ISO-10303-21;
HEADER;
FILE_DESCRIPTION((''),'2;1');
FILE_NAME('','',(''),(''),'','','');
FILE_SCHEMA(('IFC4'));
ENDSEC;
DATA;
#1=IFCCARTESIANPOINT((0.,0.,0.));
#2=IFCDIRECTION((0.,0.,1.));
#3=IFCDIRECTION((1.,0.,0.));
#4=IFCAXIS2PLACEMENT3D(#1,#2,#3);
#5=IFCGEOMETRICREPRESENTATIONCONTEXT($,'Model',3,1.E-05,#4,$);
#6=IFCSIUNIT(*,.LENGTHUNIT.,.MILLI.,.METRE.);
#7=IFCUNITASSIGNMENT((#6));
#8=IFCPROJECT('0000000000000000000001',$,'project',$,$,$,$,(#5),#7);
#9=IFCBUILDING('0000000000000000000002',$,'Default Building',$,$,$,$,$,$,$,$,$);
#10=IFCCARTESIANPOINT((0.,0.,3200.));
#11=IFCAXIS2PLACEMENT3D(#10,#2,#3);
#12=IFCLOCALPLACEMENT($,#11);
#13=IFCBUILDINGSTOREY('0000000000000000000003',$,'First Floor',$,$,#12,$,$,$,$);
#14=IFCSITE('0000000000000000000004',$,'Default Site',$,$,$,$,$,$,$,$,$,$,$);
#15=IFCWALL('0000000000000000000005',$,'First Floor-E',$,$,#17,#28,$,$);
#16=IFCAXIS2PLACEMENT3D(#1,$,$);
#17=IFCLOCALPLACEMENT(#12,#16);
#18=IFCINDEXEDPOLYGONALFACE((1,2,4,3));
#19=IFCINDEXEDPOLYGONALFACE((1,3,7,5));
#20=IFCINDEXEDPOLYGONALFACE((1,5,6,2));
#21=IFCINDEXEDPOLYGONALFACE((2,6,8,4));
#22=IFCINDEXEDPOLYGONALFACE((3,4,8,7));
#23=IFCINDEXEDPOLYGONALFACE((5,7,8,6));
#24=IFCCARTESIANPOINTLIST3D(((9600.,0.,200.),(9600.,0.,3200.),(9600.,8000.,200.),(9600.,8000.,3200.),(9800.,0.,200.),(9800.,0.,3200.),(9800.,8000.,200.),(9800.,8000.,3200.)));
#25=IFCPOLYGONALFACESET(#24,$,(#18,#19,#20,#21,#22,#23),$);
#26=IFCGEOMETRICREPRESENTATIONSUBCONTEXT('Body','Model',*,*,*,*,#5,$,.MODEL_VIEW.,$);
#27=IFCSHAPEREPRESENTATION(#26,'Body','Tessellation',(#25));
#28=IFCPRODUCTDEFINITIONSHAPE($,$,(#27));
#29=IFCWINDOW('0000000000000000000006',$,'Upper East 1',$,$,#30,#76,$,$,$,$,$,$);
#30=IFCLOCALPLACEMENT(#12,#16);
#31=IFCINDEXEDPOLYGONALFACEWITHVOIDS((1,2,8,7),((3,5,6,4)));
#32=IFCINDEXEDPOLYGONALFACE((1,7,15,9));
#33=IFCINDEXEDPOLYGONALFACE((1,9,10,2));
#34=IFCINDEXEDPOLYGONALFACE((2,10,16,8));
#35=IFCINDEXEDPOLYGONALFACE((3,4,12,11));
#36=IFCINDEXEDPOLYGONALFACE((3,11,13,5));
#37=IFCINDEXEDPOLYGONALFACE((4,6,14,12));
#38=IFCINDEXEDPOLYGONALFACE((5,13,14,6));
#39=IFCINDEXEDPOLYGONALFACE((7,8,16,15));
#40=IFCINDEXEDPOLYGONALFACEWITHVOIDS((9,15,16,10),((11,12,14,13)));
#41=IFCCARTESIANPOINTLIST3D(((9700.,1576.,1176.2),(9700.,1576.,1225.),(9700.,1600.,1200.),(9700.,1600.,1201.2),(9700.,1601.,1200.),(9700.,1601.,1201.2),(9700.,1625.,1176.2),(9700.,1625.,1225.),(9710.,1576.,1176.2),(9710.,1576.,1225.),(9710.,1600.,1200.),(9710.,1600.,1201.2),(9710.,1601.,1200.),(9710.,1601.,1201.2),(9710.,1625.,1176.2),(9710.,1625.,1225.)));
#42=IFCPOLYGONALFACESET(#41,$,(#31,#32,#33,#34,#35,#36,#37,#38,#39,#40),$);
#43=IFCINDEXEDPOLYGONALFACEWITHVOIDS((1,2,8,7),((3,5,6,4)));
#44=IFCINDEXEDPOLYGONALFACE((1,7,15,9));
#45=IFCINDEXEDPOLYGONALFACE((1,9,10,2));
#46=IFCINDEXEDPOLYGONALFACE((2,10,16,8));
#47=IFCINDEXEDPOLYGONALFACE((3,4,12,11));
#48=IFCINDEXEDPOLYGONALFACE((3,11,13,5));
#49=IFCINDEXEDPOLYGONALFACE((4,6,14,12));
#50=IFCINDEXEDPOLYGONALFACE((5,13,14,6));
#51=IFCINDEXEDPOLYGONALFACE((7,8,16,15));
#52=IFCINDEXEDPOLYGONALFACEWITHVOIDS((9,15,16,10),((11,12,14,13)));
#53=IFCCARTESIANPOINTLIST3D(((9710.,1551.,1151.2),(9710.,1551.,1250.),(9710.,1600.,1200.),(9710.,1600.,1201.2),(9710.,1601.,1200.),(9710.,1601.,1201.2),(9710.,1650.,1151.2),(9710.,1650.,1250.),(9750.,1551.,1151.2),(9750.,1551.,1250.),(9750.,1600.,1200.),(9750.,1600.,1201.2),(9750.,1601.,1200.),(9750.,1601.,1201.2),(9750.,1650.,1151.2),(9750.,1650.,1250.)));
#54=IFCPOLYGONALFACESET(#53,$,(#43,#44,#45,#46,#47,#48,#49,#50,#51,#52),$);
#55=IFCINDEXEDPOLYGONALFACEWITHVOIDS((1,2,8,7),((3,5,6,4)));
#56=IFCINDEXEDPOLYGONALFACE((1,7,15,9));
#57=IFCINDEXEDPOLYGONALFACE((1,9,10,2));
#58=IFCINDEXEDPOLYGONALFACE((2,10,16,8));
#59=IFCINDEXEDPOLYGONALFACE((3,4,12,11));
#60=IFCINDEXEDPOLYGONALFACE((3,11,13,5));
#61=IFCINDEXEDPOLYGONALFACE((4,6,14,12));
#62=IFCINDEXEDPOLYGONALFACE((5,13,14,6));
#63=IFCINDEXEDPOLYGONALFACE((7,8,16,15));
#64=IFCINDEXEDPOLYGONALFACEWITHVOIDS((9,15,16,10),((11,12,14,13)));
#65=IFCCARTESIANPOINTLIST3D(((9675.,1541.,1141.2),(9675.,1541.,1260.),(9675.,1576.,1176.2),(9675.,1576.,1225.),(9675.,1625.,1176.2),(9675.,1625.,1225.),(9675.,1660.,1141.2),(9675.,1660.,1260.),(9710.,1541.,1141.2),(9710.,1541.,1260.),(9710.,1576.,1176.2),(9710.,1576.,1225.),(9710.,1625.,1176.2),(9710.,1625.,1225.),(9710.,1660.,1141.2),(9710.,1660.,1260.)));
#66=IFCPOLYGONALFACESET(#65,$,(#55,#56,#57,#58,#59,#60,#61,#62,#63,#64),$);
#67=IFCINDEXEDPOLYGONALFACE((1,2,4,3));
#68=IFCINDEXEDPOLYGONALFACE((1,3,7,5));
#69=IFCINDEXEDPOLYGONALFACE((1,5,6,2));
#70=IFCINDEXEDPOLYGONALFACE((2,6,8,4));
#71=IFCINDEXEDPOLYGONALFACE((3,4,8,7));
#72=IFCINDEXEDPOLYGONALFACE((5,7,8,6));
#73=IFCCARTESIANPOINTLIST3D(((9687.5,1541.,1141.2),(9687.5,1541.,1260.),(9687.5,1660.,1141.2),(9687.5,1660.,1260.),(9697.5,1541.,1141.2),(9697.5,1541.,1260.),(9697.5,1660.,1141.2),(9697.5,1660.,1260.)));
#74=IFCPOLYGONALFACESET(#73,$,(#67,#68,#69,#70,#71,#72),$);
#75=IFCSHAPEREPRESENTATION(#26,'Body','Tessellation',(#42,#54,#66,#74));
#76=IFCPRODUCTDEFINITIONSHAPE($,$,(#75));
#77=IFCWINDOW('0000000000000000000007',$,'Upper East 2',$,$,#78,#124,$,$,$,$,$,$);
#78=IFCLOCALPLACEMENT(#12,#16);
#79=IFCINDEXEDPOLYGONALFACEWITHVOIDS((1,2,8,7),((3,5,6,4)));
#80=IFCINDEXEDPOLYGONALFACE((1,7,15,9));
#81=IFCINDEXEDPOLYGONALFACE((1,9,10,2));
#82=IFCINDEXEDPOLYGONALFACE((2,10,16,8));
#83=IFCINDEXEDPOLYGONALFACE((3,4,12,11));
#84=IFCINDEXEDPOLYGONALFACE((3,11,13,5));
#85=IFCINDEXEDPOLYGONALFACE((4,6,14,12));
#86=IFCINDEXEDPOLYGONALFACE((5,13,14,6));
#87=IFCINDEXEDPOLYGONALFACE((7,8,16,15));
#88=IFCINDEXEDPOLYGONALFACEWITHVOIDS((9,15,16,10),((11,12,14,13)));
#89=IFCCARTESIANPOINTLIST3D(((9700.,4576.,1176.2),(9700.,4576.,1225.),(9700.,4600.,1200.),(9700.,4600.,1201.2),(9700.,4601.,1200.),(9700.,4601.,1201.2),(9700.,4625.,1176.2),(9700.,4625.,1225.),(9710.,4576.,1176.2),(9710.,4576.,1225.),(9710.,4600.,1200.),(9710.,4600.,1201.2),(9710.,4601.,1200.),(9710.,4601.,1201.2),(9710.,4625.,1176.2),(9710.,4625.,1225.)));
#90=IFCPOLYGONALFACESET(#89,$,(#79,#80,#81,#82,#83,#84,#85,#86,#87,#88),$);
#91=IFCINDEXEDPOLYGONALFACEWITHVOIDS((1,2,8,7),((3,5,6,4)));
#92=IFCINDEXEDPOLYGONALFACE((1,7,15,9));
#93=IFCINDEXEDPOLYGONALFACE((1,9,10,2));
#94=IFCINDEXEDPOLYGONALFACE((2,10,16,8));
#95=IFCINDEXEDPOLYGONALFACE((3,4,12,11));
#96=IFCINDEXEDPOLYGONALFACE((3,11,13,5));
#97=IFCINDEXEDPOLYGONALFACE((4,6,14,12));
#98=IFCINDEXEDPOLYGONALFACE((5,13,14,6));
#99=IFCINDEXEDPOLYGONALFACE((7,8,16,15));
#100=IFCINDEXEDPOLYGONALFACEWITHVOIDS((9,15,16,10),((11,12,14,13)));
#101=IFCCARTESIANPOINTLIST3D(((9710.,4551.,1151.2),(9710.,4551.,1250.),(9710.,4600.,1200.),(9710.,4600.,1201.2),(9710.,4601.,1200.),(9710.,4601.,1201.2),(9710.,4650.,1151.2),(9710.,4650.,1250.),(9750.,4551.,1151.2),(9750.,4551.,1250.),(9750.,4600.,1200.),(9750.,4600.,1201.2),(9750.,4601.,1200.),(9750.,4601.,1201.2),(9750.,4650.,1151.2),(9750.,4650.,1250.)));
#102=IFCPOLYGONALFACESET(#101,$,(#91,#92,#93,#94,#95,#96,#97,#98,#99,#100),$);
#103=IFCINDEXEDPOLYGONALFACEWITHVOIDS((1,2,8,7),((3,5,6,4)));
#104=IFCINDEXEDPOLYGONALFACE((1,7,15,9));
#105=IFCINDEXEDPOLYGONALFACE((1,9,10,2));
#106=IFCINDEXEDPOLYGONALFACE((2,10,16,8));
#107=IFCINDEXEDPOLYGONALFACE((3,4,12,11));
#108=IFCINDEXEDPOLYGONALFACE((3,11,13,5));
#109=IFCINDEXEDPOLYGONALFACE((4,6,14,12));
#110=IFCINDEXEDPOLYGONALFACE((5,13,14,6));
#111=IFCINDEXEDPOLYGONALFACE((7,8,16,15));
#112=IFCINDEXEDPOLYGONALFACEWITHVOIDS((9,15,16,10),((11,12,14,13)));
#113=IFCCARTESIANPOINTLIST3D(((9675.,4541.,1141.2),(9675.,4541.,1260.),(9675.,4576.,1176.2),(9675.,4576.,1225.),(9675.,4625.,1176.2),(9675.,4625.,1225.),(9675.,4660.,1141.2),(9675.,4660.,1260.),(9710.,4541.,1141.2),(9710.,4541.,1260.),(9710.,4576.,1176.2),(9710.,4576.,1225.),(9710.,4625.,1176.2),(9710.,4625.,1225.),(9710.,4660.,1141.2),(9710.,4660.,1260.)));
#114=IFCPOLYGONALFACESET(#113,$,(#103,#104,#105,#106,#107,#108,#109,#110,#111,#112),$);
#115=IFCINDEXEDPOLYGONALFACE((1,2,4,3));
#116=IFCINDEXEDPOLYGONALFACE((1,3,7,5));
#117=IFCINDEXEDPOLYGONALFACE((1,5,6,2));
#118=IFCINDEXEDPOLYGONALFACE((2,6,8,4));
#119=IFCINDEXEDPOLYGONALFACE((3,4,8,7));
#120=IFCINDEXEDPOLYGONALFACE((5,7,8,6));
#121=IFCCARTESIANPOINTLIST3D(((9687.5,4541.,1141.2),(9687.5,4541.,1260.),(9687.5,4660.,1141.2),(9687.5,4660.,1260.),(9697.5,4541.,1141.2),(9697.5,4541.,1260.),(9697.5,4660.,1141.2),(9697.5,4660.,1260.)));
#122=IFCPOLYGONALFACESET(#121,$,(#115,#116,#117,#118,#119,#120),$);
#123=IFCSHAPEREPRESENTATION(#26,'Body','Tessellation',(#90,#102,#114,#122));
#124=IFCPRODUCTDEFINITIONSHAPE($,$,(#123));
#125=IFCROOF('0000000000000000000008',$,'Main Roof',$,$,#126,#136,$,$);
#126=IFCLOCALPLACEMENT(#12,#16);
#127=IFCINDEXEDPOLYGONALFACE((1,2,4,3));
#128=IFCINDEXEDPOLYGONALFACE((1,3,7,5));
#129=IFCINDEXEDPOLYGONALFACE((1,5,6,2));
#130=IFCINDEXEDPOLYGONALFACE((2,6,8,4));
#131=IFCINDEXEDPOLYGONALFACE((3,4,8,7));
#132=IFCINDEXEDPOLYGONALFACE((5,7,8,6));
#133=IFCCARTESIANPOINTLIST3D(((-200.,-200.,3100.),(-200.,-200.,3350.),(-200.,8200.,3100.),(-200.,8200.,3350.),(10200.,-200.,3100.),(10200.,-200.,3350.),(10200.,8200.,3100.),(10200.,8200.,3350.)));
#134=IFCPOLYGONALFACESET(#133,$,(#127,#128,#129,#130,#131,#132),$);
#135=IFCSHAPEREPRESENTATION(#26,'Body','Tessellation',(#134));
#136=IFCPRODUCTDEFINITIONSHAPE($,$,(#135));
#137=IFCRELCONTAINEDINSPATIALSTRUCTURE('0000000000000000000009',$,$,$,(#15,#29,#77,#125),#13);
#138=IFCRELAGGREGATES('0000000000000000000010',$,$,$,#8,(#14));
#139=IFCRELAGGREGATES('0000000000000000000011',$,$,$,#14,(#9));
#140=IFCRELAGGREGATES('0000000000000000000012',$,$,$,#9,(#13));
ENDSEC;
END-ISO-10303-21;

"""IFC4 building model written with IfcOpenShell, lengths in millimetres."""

from ifc_helpers import new_model, si_unit, frame, origin_with_axes, place, context, subcontext, project, spatial, line, indexed_curve, outline, extrude, element, fill, save


model = new_model("IFC4")

# Units and contexts
model_context = context("Model", 3, precision=1e-05, world=origin_with_axes())
body_context = subcontext(model_context, "Body", "Model", "MODEL_VIEW")
ifc_project = project(units=[si_unit("LENGTHUNIT", "METRE", prefix="MILLI")], contexts=[model_context])

# Site, building, storey
site = spatial("IfcSite", under=ifc_project, Name="Default Site")
building = spatial("IfcBuilding", under=site, Name="Default Building")
storey_placement = place(None, frame((0.0, 0.0, 3200.0), z_axis=(0.0, 0.0, 1.0), x_axis=(1.0, 0.0, 0.0)))
storey = spatial("IfcBuildingStorey", under=building, at=storey_placement, Name="First Floor")

# Wall, openings, windows
wall_1_placement = place(storey_placement, frame((0.0, 0.0, 200.0), z_axis=(0.0, 0.0, 1.0), x_axis=(1.0, 0.0, 0.0)))
wall_1 = element("IfcWall", 1, at=wall_1_placement, inside=storey, Name="First Floor-E", context=body_context, shape_type="SweptSolid", body=[
    extrude(outline(indexed_curve([(9800.0, 0.0), (9800.0, 8000.0), (9600.0, 8000.0), (9600.0, 0.0), (9800.0, 0.0)])), None, (0.0, 0.0, 1.0), 3000.0),
])
opening_1_placement = place(wall_1_placement, frame((0.0, 0.0, 1000.0), z_axis=(0.0, 0.0, 1.0), x_axis=(1.0, 0.0, 0.0)))
opening_1 = element("IfcOpeningElement", 2, at=opening_1_placement, cuts=wall_1, context=body_context, shape_type="SweptSolid", body=[
    extrude(outline(indexed_curve([(9800.0, 1600.0), (10000.0, 1600.0), (10000.0, 2600.0), (9800.0, 2600.0), (9800.0, 1600.0)])), None, (0.0, 0.0, 1.0), 1200.0),
])
opening_2_placement = place(wall_1_placement, frame((0.0, 0.0, 1000.0), z_axis=(0.0, 0.0, 1.0), x_axis=(1.0, 0.0, 0.0)))
opening_2 = element("IfcOpeningElement", 3, at=opening_2_placement, cuts=wall_1, context=body_context, shape_type="SweptSolid", body=[
    extrude(outline(indexed_curve([(9800.0, 4600.0), (10000.0, 4600.0), (10000.0, 5600.0), (9800.0, 5600.0), (9800.0, 4600.0)])), None, (0.0, 0.0, 1.0), 1200.0),
])
window_1_placement = place(storey_placement, frame((9800.0, 1600.0, 1200.0), z_axis=(0.0, 0.0, 1.0), x_axis=(0.0, 1.0, 0.0)))
window_1 = element("IfcWindow", 4, at=window_1_placement, inside=storey, Name="Upper East 1", context=body_context, shape_type="SweptSolid", body=[
    extrude(outline(indexed_curve([(0.0, 0.0), (1.0, 0.0), (1.0, 1.2), (0.0, 1.2)], segments=[line(1, 2, 3, 4, 1)]), holes=[indexed_curve([(25.0, 25.0), (-24.0, 25.0), (-24.0, -23.8), (25.0, -23.8)], segments=[line(1, 2, 3, 4, 1)])]), frame((0.0, 90.0, 0.0), z_axis=(0.0, -1.0, 0.0), x_axis=(1.0, 0.0, 0.0)), (0.0, 0.0, -1.0), 10.0),
    extrude(outline(indexed_curve([(0.0, 0.0), (1.0, 0.0), (1.0, 1.2), (0.0, 1.2)], segments=[line(1, 2, 3, 4, 1)]), holes=[indexed_curve([(50.0, 50.0), (-49.0, 50.0), (-49.0, -48.8), (50.0, -48.8)], segments=[line(1, 2, 3, 4, 1)])]), frame((0.0, 50.0, 0.0), z_axis=(0.0, -1.0, 0.0), x_axis=(1.0, 0.0, 0.0)), (0.0, 0.0, -1.0), 40.0),
    extrude(outline(indexed_curve([(0.0, 0.0), (-49.0, 0.0), (-49.0, -48.8), (0.0, -48.8)], segments=[line(1, 2, 3, 4, 1)]), holes=[indexed_curve([(35.0, 35.0), (-84.0, 35.0), (-84.0, -83.8), (35.0, -83.8)], segments=[line(1, 2, 3, 4, 1)])]), frame((25.0, 90.0, 25.0), z_axis=(0.0, -1.0, 0.0), x_axis=(1.0, 0.0, 0.0)), (0.0, 0.0, -1.0), 35.0),
    extrude(outline(indexed_curve([(35.0, 35.0), (-84.0, 35.0), (-84.0, -83.8), (35.0, -83.8)], segments=[line(1, 2, 3, 4, 1)])), frame((25.0, 102.5, 25.0), z_axis=(0.0, -1.0, 0.0), x_axis=(1.0, 0.0, 0.0)), (0.0, 0.0, -1.0), 10.0),
])
fill(opening_1, window_1)
window_2_placement = place(storey_placement, frame((9800.0, 4600.0, 1200.0), z_axis=(0.0, 0.0, 1.0), x_axis=(0.0, 1.0, 0.0)))
window_2 = element("IfcWindow", 5, at=window_2_placement, inside=storey, Name="Upper East 2", context=body_context, shape_type="SweptSolid", body=[
    extrude(outline(indexed_curve([(0.0, 0.0), (1.0, 0.0), (1.0, 1.2), (0.0, 1.2)], segments=[line(1, 2, 3, 4, 1)]), holes=[indexed_curve([(25.0, 25.0), (-24.0, 25.0), (-24.0, -23.8), (25.0, -23.8)], segments=[line(1, 2, 3, 4, 1)])]), frame((0.0, 90.0, 0.0), z_axis=(0.0, -1.0, 0.0), x_axis=(1.0, 0.0, 0.0)), (0.0, 0.0, -1.0), 10.0),
    extrude(outline(indexed_curve([(0.0, 0.0), (1.0, 0.0), (1.0, 1.2), (0.0, 1.2)], segments=[line(1, 2, 3, 4, 1)]), holes=[indexed_curve([(50.0, 50.0), (-49.0, 50.0), (-49.0, -48.8), (50.0, -48.8)], segments=[line(1, 2, 3, 4, 1)])]), frame((0.0, 50.0, 0.0), z_axis=(0.0, -1.0, 0.0), x_axis=(1.0, 0.0, 0.0)), (0.0, 0.0, -1.0), 40.0),
    extrude(outline(indexed_curve([(0.0, 0.0), (-49.0, 0.0), (-49.0, -48.8), (0.0, -48.8)], segments=[line(1, 2, 3, 4, 1)]), holes=[indexed_curve([(35.0, 35.0), (-84.0, 35.0), (-84.0, -83.8), (35.0, -83.8)], segments=[line(1, 2, 3, 4, 1)])]), frame((25.0, 90.0, 25.0), z_axis=(0.0, -1.0, 0.0), x_axis=(1.0, 0.0, 0.0)), (0.0, 0.0, -1.0), 35.0),
    extrude(outline(indexed_curve([(35.0, 35.0), (-84.0, 35.0), (-84.0, -83.8), (35.0, -83.8)], segments=[line(1, 2, 3, 4, 1)])), frame((25.0, 102.5, 25.0), z_axis=(0.0, -1.0, 0.0), x_axis=(1.0, 0.0, 0.0)), (0.0, 0.0, -1.0), 10.0),
])
fill(opening_2, window_2)

# Roof
roof_placement = place(storey_placement, frame((0.0, 0.0, 3100.0), z_axis=(0.0, 0.0, 1.0), x_axis=(1.0, 0.0, 0.0)))
element("IfcRoof", 6, at=roof_placement, inside=storey, Name="Main Roof", context=body_context, shape_type="SweptSolid", body=[
    extrude(outline(indexed_curve([(-200.0, -200.0), (10200.0, -200.0), (10200.0, 8200.0), (-200.0, 8200.0), (-200.0, -200.0)])), None, (0.0, 0.0, 1.0), 250.0),
])

save(model, "model.ifc")
